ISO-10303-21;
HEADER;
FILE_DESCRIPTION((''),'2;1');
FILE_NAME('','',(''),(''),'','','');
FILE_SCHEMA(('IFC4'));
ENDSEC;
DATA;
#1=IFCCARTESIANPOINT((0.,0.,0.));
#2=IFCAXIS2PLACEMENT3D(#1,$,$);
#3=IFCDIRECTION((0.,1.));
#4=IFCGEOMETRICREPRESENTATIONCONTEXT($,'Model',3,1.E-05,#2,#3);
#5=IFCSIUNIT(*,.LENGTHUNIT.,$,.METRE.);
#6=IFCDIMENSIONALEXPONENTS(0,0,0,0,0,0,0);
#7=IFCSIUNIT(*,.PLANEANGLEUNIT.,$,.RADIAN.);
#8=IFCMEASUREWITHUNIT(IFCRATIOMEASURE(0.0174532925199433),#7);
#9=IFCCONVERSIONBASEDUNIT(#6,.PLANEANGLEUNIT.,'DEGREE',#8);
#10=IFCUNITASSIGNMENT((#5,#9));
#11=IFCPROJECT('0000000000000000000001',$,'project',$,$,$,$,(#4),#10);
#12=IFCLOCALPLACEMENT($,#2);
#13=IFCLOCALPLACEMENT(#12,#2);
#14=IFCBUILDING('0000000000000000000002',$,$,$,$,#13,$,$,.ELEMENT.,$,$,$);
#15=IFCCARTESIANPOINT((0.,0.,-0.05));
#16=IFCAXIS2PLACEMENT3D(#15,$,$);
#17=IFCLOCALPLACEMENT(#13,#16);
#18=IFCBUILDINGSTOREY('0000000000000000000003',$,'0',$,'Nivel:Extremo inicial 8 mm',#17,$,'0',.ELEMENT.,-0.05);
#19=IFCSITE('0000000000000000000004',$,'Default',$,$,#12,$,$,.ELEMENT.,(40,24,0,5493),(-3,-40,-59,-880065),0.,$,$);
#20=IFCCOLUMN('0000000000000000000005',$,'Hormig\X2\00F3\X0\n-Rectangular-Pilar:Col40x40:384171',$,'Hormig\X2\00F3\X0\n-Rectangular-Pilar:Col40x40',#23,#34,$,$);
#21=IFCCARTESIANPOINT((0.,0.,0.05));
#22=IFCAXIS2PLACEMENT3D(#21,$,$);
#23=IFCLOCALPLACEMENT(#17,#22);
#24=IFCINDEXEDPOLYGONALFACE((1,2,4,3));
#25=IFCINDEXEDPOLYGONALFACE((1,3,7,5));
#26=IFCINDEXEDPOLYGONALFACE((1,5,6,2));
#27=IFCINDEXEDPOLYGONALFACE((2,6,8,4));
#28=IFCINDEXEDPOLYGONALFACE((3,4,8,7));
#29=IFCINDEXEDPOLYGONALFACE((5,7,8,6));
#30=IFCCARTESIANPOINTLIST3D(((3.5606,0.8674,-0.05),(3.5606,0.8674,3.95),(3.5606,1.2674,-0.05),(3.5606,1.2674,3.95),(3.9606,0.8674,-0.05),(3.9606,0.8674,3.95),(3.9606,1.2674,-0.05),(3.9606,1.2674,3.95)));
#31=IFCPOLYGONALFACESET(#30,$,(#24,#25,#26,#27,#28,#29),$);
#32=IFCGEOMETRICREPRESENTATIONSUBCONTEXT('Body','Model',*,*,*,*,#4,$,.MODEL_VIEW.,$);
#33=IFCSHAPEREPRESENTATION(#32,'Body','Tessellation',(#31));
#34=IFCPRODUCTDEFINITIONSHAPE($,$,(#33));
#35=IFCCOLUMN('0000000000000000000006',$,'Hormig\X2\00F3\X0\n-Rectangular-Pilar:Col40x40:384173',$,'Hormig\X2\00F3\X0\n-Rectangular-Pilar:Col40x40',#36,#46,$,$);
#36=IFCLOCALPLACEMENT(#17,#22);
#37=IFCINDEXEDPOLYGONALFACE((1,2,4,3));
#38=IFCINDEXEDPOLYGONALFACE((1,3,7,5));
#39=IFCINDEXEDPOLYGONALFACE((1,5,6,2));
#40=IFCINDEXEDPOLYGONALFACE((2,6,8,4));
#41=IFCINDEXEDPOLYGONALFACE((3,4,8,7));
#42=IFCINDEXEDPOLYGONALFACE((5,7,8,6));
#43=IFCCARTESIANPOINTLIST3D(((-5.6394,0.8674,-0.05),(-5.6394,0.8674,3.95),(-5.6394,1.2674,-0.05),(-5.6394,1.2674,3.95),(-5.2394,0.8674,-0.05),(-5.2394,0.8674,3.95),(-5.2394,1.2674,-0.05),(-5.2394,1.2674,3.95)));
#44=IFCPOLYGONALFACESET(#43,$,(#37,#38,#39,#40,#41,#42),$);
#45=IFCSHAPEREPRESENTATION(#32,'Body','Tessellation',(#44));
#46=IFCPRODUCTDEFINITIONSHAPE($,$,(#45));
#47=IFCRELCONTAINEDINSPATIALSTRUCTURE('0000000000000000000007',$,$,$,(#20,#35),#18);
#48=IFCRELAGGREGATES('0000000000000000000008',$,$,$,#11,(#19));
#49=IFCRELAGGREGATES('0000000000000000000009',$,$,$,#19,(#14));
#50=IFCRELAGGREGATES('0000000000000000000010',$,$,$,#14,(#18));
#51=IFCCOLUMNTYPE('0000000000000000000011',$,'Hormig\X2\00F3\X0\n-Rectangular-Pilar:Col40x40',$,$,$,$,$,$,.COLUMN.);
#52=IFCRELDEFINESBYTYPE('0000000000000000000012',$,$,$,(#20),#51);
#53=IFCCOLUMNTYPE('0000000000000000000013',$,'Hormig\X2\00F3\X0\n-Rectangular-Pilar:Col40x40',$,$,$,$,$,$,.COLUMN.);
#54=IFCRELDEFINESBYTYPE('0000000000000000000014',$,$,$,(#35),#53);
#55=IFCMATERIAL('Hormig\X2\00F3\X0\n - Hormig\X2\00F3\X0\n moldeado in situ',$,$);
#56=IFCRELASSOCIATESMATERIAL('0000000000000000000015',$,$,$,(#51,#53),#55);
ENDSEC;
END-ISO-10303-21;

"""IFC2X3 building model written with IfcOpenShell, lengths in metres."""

from ifc_helpers import new_model, entity, si_unit, converted_unit, direction, frame, origin, origin_2d_with_axis, place, context, subcontext, project, spatial, rectangle, extrude, source, transform, mapped, material, type_object, type_shapes, element, save


model = new_model("IFC2X3")

# Units and contexts
model_context = context("Model", 3, precision=1e-05, world=origin(), true_north=direction((0.0, 1.0)))
body_context = subcontext(model_context, "Body", "Model", "MODEL_VIEW")
ifc_project = project(units=[si_unit("LENGTHUNIT", "METRE"), converted_unit("PLANEANGLEUNIT", "DEGREE", entity("IfcRatioMeasure", 0.0174532925199433), si_unit("PLANEANGLEUNIT", "RADIAN"), dimensions=[0, 0, 0, 0, 0, 0, 0])], contexts=[model_context])

# Site, building, storey
site_placement = place(None, origin())
site = spatial("IfcSite", under=ifc_project, at=site_placement, Name="Default", CompositionType="ELEMENT", RefLatitude=(40, 24, 0, 5493), RefLongitude=(-3, -40, -59, -880065), RefElevation=0.0)
building_placement = place(site_placement, origin())
building = spatial("IfcBuilding", under=site, at=building_placement, CompositionType="ELEMENT")
storey_placement = place(building_placement, frame((0.0, 0.0, -0.05)))
storey = spatial("IfcBuildingStorey", under=building, at=storey_placement, Name="0", ObjectType="Nivel:Extremo inicial 8 mm", LongName="0", CompositionType="ELEMENT", Elevation=-0.05)

# Columns
ifc_material_1 = material(Name="Hormigón - Hormigón moldeado in situ")
column_type_1 = type_object("IfcColumnType", Name="Hormigón-Rectangular-Pilar:Col40x40", PredefinedType="COLUMN", material=ifc_material_1)
shared_shape_1 = source(origin(), body_context, "Body", "SweptSolid", [
    extrude(rectangle(XDim=0.4, YDim=0.4, at=origin_2d_with_axis()), frame((3.7606, 1.0674, -0.05), z_axis=(0.0, 0.0, 1.0), x_axis=(0.0, -1.0, 0.0)), (0.0, 0.0, 1.0), 4.0),
])
type_shapes(column_type_1, [shared_shape_1])
column_1_placement = place(storey_placement, frame((0.0, 0.0, 0.05)))
element("IfcColumn", 1, at=column_1_placement, inside=storey, type_object=column_type_1, Name="Hormigón-Rectangular-Pilar:Col40x40:384171", ObjectType="Hormigón-Rectangular-Pilar:Col40x40", context=body_context, shape_type="MappedRepresentation", body=[
    mapped(shared_shape_1, transform((0.0, 0.0, 0.0), scale=1.0)),
])
column_type_2 = type_object("IfcColumnType", Name="Hormigón-Rectangular-Pilar:Col40x40", PredefinedType="COLUMN", material=ifc_material_1)
shared_shape_2 = source(origin(), body_context, "Body", "SweptSolid", [
    extrude(rectangle(XDim=0.4, YDim=0.4, at=origin_2d_with_axis()), frame((-5.4394, 1.0674, -0.05), z_axis=(0.0, 0.0, 1.0), x_axis=(0.0, -1.0, 0.0)), (0.0, 0.0, 1.0), 4.0),
])
type_shapes(column_type_2, [shared_shape_2])
column_2_placement = place(storey_placement, frame((0.0, 0.0, 0.05)))
element("IfcColumn", 2, at=column_2_placement, inside=storey, type_object=column_type_2, Name="Hormigón-Rectangular-Pilar:Col40x40:384173", ObjectType="Hormigón-Rectangular-Pilar:Col40x40", context=body_context, shape_type="MappedRepresentation", body=[
    mapped(shared_shape_2, transform((0.0, 0.0, 0.0), scale=1.0)),
])

save(model, "model.ifc")
